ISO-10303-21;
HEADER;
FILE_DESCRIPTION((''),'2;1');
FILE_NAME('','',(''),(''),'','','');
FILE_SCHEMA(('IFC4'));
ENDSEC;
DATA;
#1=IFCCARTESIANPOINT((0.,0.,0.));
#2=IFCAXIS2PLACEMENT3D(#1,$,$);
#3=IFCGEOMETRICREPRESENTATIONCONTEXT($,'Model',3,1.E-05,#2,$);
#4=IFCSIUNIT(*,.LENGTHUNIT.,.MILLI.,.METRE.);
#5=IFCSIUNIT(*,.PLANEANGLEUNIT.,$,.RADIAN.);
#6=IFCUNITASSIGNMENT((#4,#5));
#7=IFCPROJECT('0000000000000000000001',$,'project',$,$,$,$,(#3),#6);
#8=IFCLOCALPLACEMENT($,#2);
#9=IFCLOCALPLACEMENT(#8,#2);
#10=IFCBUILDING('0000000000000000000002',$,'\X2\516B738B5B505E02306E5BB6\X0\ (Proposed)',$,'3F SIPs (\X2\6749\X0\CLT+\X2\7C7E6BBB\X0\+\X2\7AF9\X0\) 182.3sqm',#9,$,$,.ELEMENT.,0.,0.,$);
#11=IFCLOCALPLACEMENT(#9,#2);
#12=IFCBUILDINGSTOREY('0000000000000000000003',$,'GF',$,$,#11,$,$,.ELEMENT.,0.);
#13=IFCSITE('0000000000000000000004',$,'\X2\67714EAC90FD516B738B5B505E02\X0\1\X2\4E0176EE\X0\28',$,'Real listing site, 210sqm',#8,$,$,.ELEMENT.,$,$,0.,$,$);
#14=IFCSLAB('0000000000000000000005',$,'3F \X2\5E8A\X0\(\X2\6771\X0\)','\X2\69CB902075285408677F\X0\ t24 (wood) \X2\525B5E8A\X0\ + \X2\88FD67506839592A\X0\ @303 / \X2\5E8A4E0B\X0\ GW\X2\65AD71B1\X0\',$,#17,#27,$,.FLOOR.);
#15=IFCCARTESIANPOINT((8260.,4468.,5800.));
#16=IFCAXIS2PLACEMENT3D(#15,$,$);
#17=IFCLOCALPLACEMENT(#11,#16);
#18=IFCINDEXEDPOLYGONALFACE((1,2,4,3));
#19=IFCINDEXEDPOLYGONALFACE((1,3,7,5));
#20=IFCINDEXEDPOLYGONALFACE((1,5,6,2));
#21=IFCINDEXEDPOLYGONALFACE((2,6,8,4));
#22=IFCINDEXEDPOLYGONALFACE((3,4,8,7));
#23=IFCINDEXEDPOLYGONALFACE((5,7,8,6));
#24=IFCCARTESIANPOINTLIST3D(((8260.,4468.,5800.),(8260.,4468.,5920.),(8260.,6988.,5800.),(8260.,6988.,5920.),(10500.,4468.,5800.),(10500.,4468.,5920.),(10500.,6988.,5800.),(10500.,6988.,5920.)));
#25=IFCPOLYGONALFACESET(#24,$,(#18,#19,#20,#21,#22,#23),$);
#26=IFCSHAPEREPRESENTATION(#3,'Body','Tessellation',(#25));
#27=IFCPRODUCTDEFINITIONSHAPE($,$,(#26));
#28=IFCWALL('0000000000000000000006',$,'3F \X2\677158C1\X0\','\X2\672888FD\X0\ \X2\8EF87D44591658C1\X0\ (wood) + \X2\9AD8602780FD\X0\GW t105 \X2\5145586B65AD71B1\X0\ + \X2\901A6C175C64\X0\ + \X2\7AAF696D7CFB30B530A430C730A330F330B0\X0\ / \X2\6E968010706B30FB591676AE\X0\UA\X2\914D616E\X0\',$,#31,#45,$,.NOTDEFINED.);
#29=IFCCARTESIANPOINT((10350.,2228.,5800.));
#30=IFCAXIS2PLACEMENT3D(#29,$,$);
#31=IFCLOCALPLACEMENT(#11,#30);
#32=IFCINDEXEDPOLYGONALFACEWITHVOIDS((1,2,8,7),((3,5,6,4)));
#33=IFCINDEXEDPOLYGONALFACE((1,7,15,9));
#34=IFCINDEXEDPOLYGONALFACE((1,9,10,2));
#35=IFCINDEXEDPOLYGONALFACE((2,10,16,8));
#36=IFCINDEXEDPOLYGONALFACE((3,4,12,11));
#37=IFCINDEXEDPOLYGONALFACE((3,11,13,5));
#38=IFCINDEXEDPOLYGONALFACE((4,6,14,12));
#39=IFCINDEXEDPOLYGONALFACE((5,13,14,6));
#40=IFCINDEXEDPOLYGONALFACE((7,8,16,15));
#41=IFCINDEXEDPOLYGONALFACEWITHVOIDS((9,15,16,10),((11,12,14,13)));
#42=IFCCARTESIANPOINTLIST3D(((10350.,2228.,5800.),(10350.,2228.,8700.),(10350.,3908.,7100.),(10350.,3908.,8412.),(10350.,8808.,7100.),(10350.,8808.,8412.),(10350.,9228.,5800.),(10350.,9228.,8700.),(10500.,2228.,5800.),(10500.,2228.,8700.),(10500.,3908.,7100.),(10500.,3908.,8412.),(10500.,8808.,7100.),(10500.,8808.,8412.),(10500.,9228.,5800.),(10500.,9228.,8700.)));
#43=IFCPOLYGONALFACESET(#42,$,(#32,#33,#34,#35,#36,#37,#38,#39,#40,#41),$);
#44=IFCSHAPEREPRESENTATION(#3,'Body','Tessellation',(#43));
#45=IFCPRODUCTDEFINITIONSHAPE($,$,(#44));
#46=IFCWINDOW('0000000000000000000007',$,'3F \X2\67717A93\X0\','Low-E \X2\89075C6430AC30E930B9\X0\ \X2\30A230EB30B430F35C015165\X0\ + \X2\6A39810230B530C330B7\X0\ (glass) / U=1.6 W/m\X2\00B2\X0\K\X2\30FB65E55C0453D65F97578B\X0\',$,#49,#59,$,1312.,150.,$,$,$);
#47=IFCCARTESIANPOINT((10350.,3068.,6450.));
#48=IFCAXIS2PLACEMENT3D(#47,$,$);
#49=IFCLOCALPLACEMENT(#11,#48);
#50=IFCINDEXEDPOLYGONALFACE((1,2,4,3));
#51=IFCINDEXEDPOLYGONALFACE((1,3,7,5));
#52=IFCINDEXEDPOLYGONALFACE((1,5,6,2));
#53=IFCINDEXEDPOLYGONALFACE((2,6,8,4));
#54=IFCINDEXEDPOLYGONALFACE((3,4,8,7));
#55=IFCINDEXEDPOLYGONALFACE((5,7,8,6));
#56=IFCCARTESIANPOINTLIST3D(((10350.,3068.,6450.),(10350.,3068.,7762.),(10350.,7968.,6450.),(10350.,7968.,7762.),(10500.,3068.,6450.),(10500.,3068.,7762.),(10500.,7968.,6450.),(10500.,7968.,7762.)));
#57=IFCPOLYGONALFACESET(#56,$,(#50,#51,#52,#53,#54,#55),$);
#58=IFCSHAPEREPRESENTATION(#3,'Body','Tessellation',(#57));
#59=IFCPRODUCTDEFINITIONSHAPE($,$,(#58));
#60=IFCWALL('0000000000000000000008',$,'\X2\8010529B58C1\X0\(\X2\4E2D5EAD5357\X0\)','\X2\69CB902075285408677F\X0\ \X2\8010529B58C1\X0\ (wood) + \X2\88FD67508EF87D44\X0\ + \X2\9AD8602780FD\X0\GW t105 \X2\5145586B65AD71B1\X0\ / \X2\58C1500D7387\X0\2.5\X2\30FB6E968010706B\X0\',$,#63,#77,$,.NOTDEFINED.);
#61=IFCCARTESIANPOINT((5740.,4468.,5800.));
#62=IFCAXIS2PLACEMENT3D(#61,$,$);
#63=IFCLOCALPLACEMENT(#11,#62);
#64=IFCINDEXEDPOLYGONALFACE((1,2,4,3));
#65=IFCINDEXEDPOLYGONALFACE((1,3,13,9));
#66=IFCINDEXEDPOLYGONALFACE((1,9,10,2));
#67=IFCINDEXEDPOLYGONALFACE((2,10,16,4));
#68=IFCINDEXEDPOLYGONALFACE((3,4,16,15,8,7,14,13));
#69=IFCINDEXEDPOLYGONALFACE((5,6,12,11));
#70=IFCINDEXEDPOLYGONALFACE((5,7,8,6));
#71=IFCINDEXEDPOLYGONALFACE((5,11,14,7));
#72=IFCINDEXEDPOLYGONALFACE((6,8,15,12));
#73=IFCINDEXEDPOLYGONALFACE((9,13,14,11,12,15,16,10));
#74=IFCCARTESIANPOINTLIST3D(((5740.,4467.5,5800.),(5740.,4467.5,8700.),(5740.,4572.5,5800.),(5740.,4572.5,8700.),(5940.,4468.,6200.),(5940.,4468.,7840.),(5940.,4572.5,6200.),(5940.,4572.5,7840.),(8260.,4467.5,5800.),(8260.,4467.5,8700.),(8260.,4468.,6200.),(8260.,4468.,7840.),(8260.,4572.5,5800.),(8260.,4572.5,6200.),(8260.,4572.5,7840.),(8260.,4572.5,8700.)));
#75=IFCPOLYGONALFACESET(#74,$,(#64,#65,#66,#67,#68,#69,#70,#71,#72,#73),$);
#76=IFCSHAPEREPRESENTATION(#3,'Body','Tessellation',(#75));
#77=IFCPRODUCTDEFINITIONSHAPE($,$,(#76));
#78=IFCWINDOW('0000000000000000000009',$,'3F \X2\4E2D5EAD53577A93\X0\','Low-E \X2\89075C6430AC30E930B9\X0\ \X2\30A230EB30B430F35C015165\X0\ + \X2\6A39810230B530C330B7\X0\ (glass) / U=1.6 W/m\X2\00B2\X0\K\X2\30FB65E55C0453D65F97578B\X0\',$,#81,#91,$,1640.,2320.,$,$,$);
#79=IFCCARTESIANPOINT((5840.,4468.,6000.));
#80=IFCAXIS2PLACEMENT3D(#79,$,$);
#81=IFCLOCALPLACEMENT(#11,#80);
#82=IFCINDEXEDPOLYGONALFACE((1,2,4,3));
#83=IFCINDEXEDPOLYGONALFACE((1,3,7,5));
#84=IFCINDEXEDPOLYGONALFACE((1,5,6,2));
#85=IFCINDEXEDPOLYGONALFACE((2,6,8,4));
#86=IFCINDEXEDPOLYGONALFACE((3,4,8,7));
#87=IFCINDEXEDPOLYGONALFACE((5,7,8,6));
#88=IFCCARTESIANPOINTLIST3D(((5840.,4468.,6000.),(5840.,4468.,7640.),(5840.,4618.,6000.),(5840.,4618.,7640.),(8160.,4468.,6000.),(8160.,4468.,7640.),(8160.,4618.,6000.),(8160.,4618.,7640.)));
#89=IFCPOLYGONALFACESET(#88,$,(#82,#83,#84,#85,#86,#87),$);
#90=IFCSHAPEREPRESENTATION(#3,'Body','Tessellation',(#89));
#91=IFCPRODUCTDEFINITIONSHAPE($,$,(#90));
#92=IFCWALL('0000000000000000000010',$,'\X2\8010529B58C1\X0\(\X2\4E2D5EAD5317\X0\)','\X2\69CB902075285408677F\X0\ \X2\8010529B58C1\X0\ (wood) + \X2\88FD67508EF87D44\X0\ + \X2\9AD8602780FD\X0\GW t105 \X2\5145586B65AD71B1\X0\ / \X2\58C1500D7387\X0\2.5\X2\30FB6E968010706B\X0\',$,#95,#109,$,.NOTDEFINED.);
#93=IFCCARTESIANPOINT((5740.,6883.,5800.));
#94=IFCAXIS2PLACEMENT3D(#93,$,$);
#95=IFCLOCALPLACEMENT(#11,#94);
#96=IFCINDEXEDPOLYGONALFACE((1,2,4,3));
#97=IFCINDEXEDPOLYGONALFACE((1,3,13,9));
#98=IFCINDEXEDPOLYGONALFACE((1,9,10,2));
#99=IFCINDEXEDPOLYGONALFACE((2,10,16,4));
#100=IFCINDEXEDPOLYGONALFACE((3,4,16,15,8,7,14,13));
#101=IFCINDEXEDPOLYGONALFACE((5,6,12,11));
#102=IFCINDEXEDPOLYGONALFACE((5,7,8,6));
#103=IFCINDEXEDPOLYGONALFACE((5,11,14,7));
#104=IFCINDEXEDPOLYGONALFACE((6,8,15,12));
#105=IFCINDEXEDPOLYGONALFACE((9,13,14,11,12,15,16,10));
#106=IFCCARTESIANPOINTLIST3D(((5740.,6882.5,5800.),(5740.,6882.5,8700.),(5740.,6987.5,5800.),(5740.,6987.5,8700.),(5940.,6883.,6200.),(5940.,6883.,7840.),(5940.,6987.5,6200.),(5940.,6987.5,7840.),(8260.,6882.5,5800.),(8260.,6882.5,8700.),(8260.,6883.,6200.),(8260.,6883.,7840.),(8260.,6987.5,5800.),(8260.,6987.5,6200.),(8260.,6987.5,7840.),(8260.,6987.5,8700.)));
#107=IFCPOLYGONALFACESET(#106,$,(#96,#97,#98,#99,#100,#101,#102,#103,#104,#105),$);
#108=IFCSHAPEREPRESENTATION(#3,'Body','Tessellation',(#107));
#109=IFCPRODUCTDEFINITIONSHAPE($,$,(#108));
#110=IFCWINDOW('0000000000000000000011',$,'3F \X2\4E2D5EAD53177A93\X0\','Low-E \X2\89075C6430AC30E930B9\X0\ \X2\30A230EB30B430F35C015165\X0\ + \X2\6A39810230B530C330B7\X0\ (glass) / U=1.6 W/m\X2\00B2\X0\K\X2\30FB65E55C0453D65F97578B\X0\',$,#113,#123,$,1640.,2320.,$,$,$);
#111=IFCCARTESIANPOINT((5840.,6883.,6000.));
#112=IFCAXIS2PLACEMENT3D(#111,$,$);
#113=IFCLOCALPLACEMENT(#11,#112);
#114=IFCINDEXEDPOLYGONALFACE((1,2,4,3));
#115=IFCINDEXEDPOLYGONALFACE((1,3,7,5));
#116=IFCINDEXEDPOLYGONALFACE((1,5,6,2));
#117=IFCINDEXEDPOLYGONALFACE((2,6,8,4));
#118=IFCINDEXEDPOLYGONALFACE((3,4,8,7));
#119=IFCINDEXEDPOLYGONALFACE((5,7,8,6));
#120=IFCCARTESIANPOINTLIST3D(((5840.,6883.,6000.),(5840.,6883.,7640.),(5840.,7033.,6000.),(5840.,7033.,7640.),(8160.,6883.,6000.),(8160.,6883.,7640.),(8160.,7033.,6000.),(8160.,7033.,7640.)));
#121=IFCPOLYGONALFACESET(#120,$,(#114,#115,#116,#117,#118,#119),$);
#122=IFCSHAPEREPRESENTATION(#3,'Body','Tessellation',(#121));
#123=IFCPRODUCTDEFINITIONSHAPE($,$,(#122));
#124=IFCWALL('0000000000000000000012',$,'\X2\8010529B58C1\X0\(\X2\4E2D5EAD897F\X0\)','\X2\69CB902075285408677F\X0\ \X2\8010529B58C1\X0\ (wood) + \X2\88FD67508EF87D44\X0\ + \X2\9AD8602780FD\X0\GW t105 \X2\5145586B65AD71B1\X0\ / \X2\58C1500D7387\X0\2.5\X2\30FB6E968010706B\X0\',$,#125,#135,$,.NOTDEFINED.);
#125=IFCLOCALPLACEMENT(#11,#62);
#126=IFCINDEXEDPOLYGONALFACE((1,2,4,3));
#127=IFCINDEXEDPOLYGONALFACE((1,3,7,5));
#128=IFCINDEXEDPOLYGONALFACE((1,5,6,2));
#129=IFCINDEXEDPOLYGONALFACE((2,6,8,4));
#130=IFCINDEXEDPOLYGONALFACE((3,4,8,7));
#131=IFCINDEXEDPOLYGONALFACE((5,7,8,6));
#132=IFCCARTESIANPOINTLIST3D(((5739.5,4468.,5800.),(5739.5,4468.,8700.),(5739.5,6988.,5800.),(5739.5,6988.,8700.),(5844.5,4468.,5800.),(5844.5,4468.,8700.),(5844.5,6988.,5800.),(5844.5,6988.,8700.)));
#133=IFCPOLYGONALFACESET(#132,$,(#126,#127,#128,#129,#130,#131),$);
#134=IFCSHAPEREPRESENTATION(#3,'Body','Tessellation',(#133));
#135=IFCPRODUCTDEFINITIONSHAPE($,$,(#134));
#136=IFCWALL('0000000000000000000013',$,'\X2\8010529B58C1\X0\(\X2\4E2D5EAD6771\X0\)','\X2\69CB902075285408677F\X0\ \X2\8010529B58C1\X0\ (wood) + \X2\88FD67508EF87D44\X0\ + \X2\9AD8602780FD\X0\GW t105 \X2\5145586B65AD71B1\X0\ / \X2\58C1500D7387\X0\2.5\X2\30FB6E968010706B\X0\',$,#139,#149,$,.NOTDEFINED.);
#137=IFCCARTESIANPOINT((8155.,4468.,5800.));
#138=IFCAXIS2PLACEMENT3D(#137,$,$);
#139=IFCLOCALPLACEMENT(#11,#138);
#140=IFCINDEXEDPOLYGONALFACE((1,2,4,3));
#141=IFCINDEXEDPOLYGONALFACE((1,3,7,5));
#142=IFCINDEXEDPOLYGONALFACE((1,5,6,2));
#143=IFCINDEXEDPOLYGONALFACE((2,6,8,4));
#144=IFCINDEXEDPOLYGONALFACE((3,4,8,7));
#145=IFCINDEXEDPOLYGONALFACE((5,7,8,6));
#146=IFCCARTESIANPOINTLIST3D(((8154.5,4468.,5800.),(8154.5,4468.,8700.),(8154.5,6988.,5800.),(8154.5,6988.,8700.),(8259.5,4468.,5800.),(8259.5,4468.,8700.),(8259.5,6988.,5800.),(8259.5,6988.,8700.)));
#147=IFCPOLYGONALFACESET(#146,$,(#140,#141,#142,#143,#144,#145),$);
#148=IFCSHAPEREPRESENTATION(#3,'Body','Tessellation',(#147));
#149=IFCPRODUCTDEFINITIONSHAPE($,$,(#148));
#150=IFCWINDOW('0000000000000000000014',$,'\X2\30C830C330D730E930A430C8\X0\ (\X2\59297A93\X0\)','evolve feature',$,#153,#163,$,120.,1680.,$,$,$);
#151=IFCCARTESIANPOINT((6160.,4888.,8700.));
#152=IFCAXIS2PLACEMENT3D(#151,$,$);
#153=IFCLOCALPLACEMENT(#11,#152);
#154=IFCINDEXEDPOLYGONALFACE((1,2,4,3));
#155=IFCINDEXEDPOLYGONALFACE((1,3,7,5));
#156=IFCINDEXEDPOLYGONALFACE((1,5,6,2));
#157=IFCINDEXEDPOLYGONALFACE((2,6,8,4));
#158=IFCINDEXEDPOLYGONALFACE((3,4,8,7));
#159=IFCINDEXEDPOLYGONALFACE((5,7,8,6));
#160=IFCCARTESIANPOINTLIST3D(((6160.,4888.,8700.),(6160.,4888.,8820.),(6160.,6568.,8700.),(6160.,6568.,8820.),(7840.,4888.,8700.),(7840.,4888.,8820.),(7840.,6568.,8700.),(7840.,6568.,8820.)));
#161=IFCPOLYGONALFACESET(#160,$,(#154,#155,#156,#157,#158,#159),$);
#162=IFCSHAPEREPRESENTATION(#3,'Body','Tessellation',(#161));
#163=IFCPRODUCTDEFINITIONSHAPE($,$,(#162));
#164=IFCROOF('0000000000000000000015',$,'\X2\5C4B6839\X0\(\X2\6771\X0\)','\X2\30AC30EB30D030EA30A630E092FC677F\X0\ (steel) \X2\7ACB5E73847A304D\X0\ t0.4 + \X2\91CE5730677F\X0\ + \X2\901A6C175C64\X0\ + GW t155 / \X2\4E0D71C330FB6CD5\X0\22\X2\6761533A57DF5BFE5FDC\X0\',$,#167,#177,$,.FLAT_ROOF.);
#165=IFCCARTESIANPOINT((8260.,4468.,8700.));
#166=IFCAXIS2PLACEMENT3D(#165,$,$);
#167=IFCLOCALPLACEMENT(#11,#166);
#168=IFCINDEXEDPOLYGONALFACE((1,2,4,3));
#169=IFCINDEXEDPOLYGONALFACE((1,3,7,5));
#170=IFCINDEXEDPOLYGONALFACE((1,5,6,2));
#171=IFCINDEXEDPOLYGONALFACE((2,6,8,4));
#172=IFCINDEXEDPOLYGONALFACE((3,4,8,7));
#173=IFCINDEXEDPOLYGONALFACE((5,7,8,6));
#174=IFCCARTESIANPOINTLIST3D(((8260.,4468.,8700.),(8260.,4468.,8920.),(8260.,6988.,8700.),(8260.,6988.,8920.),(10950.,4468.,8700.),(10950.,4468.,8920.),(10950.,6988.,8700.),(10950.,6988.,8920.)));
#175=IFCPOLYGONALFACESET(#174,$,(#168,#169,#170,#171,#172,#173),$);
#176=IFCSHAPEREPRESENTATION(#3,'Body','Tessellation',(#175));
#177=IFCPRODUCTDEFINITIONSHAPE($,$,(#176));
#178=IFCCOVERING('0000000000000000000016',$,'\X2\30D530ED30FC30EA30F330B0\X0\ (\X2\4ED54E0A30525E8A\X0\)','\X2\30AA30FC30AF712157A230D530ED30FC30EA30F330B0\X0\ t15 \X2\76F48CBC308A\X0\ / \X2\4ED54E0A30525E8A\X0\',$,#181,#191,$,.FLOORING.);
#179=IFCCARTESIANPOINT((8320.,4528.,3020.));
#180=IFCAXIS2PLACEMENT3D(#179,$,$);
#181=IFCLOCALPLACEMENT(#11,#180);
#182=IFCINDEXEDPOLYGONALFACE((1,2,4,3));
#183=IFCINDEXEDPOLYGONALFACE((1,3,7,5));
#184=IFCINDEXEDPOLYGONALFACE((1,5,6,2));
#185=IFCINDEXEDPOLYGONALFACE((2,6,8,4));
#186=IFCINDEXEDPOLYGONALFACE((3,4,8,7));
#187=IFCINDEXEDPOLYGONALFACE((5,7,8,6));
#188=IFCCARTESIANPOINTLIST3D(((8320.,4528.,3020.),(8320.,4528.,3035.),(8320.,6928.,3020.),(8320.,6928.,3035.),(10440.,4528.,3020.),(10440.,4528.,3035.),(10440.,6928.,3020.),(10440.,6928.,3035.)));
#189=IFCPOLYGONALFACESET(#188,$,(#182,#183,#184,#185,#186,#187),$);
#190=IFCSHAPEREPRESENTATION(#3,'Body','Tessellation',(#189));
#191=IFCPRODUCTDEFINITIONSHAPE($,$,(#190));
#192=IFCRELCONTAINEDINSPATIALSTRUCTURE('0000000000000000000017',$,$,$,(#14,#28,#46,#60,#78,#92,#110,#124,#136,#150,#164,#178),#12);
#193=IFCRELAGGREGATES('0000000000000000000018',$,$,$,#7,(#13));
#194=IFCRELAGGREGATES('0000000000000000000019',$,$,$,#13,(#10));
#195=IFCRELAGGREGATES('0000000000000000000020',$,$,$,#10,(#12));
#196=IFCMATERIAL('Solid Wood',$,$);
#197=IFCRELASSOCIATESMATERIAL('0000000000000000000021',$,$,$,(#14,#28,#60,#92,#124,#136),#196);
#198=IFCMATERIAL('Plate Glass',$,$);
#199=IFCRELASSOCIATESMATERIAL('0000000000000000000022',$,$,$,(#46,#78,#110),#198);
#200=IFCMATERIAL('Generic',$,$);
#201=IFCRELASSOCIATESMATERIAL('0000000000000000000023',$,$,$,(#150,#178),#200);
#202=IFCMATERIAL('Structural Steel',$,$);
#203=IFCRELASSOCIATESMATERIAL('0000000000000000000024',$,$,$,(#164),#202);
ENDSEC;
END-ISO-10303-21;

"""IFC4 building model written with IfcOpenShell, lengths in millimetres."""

from ifc_helpers import new_model, si_unit, frame, frame_2d, origin, place, context, project, spatial, rectangle, extrude, material, element, fill, save


model = new_model("IFC4")

# Units and contexts
model_context = context("Model", 3, precision=1e-05, world=origin())
ifc_project = project(units=[si_unit("LENGTHUNIT", "METRE", prefix="MILLI"), si_unit("PLANEANGLEUNIT", "RADIAN")], contexts=[model_context])

# Site, building, storey
site_placement = place(None, origin())
site = spatial("IfcSite", under=ifc_project, at=site_placement, Name="東京都八王子市1丁目28", ObjectType="Real listing site, 210sqm", CompositionType="ELEMENT", RefElevation=0.0)
building_placement = place(site_placement, origin())
building = spatial("IfcBuilding", under=site, at=building_placement, Name="八王子市の家 (Proposed)", ObjectType="3F SIPs (杉CLT+籾殻+竹) 182.3sqm", CompositionType="ELEMENT", ElevationOfRefHeight=0.0, ElevationOfTerrain=0.0)
storey_placement = place(building_placement, origin())
storey = spatial("IfcBuildingStorey", under=building, at=storey_placement, Name="GF", CompositionType="ELEMENT", Elevation=0.0)

# Slab
ifc_material_1 = material(Name="Solid Wood")
slab_placement = place(storey_placement, frame((8260.0, 4468.0, 5800.0)))
element("IfcSlab", 1, at=slab_placement, inside=storey, material=ifc_material_1, Name="3F 床(東)", Description="構造用合板 t24 (wood) 剛床 + 製材根太 @303 / 床下 GW断熱", PredefinedType="FLOOR", context=model_context, shape_type="SweptSolid", body=[
    extrude(rectangle(XDim=2240.0, YDim=2520.0, at=frame_2d((1120.0, 1260.0))), frame((8260.0, 4468.0, 5800.0)), (0.0, 0.0, 1.0), 120.0),
])

# Walls, openings, windows
wall_1_placement = place(storey_placement, frame((10350.0, 2228.0, 5800.0)))
wall_1 = element("IfcWall", 2, at=wall_1_placement, inside=storey, material=ifc_material_1, Name="3F 東壁", Description="木製 軸組外壁 (wood) + 高性能GW t105 充填断熱 + 通気層 + 窯業系サイディング / 準耐火・外皮UA配慮", PredefinedType="NOTDEFINED", context=model_context, shape_type="SweptSolid", body=[
    extrude(rectangle(XDim=150.0, YDim=7000.0, at=frame_2d((75.0, 3500.0))), frame((10350.0, 2228.0, 5800.0)), (0.0, 0.0, 1.0), 2900.0),
])
opening_1_placement = place(storey_placement, frame((10350.0, 3068.0, 6450.0)))
opening_1 = element("IfcOpeningElement", 3, at=opening_1_placement, cuts=wall_1, PredefinedType="NOTDEFINED", context=model_context, shape_type="SweptSolid", body=[
    extrude(rectangle(XDim=150.0, YDim=4900.0, at=frame_2d((75.0, 2450.0))), frame((10350.0, 3068.0, 6450.0)), (0.0, 0.0, 1.0), 1312.0),
])
ifc_material_2 = material(Name="Plate Glass")
window_1_placement = place(storey_placement, frame((10350.0, 3068.0, 6450.0)))
window_1 = element("IfcWindow", 4, at=window_1_placement, inside=storey, material=ifc_material_2, Name="3F 東窓", Description="Low-E 複層ガラス アルゴン封入 + 樹脂サッシ (glass) / U=1.6 W/m²K・日射取得型", OverallHeight=1312.0, OverallWidth=150.0, context=model_context, shape_type="SweptSolid", body=[
    extrude(rectangle(XDim=150.0, YDim=4900.0, at=frame_2d((75.0, 2450.0))), frame((10350.0, 3068.0, 6450.0)), (0.0, 0.0, 1.0), 1312.0),
])
fill(opening_1, window_1)
wall_2_placement = place(storey_placement, frame((5740.0, 4468.0, 5800.0)))
wall_2 = element("IfcWall", 5, at=wall_2_placement, inside=storey, material=ifc_material_1, Name="耐力壁(中庭南)", Description="構造用合板 耐力壁 (wood) + 製材軸組 + 高性能GW t105 充填断熱 / 壁倍率2.5・準耐火", PredefinedType="NOTDEFINED", context=model_context, shape_type="SweptSolid", body=[
    extrude(rectangle(XDim=2520.0, YDim=105.0, at=frame_2d((1260.0, 52.0))), frame((5740.0, 4468.0, 5800.0)), (0.0, 0.0, 1.0), 2900.0),
])
opening_2_placement = place(storey_placement, frame((5840.0, 4468.0, 6000.0)))
opening_2 = element("IfcOpeningElement", 6, at=opening_2_placement, cuts=wall_2, PredefinedType="NOTDEFINED", context=model_context, shape_type="SweptSolid", body=[
    extrude(rectangle(XDim=2320.0, YDim=150.0, at=frame_2d((1160.0, 75.0))), frame((5840.0, 4468.0, 6000.0)), (0.0, 0.0, 1.0), 1640.0),
])
window_2_placement = place(storey_placement, frame((5840.0, 4468.0, 6000.0)))
window_2 = element("IfcWindow", 7, at=window_2_placement, inside=storey, material=ifc_material_2, Name="3F 中庭南窓", Description="Low-E 複層ガラス アルゴン封入 + 樹脂サッシ (glass) / U=1.6 W/m²K・日射取得型", OverallHeight=1640.0, OverallWidth=2320.0, context=model_context, shape_type="SweptSolid", body=[
    extrude(rectangle(XDim=2320.0, YDim=150.0, at=frame_2d((1160.0, 75.0))), frame((5840.0, 4468.0, 6000.0)), (0.0, 0.0, 1.0), 1640.0),
])
fill(opening_2, window_2)
wall_3_placement = place(storey_placement, frame((5740.0, 6883.0, 5800.0)))
wall_3 = element("IfcWall", 8, at=wall_3_placement, inside=storey, material=ifc_material_1, Name="耐力壁(中庭北)", Description="構造用合板 耐力壁 (wood) + 製材軸組 + 高性能GW t105 充填断熱 / 壁倍率2.5・準耐火", PredefinedType="NOTDEFINED", context=model_context, shape_type="SweptSolid", body=[
    extrude(rectangle(XDim=2520.0, YDim=105.0, at=frame_2d((1260.0, 52.0))), frame((5740.0, 6883.0, 5800.0)), (0.0, 0.0, 1.0), 2900.0),
])
opening_3_placement = place(storey_placement, frame((5840.0, 6883.0, 6000.0)))
opening_3 = element("IfcOpeningElement", 9, at=opening_3_placement, cuts=wall_3, PredefinedType="NOTDEFINED", context=model_context, shape_type="SweptSolid", body=[
    extrude(rectangle(XDim=2320.0, YDim=150.0, at=frame_2d((1160.0, 75.0))), frame((5840.0, 6883.0, 6000.0)), (0.0, 0.0, 1.0), 1640.0),
])
window_3_placement = place(storey_placement, frame((5840.0, 6883.0, 6000.0)))
window_3 = element("IfcWindow", 10, at=window_3_placement, inside=storey, material=ifc_material_2, Name="3F 中庭北窓", Description="Low-E 複層ガラス アルゴン封入 + 樹脂サッシ (glass) / U=1.6 W/m²K・日射取得型", OverallHeight=1640.0, OverallWidth=2320.0, context=model_context, shape_type="SweptSolid", body=[
    extrude(rectangle(XDim=2320.0, YDim=150.0, at=frame_2d((1160.0, 75.0))), frame((5840.0, 6883.0, 6000.0)), (0.0, 0.0, 1.0), 1640.0),
])
fill(opening_3, window_3)

# Walls
wall_4_placement = place(storey_placement, frame((5740.0, 4468.0, 5800.0)))
element("IfcWall", 11, at=wall_4_placement, inside=storey, material=ifc_material_1, Name="耐力壁(中庭西)", Description="構造用合板 耐力壁 (wood) + 製材軸組 + 高性能GW t105 充填断熱 / 壁倍率2.5・準耐火", PredefinedType="NOTDEFINED", context=model_context, shape_type="SweptSolid", body=[
    extrude(rectangle(XDim=105.0, YDim=2520.0, at=frame_2d((52.0, 1260.0))), frame((5740.0, 4468.0, 5800.0)), (0.0, 0.0, 1.0), 2900.0),
])
wall_5_placement = place(storey_placement, frame((8155.0, 4468.0, 5800.0)))
element("IfcWall", 12, at=wall_5_placement, inside=storey, material=ifc_material_1, Name="耐力壁(中庭東)", Description="構造用合板 耐力壁 (wood) + 製材軸組 + 高性能GW t105 充填断熱 / 壁倍率2.5・準耐火", PredefinedType="NOTDEFINED", context=model_context, shape_type="SweptSolid", body=[
    extrude(rectangle(XDim=105.0, YDim=2520.0, at=frame_2d((52.0, 1260.0))), frame((8155.0, 4468.0, 5800.0)), (0.0, 0.0, 1.0), 2900.0),
])

# Window
ifc_material_3 = material(Name="Generic")
window_4_placement = place(storey_placement, frame((6160.0, 4888.0, 8700.0)))
element("IfcWindow", 13, at=window_4_placement, inside=storey, material=ifc_material_3, Name="トップライト (天窓)", Description="evolve feature", OverallHeight=120.0, OverallWidth=1680.0, context=model_context, shape_type="SweptSolid", body=[
    extrude(rectangle(XDim=1680.0, YDim=1680.0, at=frame_2d((840.0, 840.0))), frame((6160.0, 4888.0, 8700.0)), (0.0, 0.0, 1.0), 120.0),
])

# Roof
ifc_material_4 = material(Name="Structural Steel")
for number, where, name in (
    (14, (8260.0, 4468.0, 8700.0), "屋根(東)"),
):
    element("IfcRoof", number, at=place(storey_placement, frame(where)), inside=storey, material=ifc_material_4, Name=name, Description="ガルバリウム鋼板 (steel) 立平葺き t0.4 + 野地板 + 通気層 + GW t155 / 不燃・法22条区域対応", PredefinedType="FLAT_ROOF", context=model_context, shape_type="SweptSolid", body=[
        extrude(rectangle(XDim=2690.0, YDim=2520.0, at=frame_2d((1345.0, 1260.0))), frame((8260.0, 4468.0, 8700.0)), (0.0, 0.0, 1.0), 220.0),
    ])

# Covering
covering_1_placement = place(storey_placement, frame((8320.0, 4528.0, 3020.0)))
element("IfcCovering", 15, at=covering_1_placement, inside=storey, material=ifc_material_3, Name="フローリング (仕上げ床)", Description="オーク無垢フローリング t15 直貼り / 仕上げ床", PredefinedType="FLOORING", context=model_context, shape_type="SweptSolid", body=[
    extrude(rectangle(XDim=2120.0, YDim=2400.0, at=frame_2d((1060.0, 1200.0))), frame((8320.0, 4528.0, 3020.0)), (0.0, 0.0, 1.0), 15.0),
])

save(model, "model.ifc")
